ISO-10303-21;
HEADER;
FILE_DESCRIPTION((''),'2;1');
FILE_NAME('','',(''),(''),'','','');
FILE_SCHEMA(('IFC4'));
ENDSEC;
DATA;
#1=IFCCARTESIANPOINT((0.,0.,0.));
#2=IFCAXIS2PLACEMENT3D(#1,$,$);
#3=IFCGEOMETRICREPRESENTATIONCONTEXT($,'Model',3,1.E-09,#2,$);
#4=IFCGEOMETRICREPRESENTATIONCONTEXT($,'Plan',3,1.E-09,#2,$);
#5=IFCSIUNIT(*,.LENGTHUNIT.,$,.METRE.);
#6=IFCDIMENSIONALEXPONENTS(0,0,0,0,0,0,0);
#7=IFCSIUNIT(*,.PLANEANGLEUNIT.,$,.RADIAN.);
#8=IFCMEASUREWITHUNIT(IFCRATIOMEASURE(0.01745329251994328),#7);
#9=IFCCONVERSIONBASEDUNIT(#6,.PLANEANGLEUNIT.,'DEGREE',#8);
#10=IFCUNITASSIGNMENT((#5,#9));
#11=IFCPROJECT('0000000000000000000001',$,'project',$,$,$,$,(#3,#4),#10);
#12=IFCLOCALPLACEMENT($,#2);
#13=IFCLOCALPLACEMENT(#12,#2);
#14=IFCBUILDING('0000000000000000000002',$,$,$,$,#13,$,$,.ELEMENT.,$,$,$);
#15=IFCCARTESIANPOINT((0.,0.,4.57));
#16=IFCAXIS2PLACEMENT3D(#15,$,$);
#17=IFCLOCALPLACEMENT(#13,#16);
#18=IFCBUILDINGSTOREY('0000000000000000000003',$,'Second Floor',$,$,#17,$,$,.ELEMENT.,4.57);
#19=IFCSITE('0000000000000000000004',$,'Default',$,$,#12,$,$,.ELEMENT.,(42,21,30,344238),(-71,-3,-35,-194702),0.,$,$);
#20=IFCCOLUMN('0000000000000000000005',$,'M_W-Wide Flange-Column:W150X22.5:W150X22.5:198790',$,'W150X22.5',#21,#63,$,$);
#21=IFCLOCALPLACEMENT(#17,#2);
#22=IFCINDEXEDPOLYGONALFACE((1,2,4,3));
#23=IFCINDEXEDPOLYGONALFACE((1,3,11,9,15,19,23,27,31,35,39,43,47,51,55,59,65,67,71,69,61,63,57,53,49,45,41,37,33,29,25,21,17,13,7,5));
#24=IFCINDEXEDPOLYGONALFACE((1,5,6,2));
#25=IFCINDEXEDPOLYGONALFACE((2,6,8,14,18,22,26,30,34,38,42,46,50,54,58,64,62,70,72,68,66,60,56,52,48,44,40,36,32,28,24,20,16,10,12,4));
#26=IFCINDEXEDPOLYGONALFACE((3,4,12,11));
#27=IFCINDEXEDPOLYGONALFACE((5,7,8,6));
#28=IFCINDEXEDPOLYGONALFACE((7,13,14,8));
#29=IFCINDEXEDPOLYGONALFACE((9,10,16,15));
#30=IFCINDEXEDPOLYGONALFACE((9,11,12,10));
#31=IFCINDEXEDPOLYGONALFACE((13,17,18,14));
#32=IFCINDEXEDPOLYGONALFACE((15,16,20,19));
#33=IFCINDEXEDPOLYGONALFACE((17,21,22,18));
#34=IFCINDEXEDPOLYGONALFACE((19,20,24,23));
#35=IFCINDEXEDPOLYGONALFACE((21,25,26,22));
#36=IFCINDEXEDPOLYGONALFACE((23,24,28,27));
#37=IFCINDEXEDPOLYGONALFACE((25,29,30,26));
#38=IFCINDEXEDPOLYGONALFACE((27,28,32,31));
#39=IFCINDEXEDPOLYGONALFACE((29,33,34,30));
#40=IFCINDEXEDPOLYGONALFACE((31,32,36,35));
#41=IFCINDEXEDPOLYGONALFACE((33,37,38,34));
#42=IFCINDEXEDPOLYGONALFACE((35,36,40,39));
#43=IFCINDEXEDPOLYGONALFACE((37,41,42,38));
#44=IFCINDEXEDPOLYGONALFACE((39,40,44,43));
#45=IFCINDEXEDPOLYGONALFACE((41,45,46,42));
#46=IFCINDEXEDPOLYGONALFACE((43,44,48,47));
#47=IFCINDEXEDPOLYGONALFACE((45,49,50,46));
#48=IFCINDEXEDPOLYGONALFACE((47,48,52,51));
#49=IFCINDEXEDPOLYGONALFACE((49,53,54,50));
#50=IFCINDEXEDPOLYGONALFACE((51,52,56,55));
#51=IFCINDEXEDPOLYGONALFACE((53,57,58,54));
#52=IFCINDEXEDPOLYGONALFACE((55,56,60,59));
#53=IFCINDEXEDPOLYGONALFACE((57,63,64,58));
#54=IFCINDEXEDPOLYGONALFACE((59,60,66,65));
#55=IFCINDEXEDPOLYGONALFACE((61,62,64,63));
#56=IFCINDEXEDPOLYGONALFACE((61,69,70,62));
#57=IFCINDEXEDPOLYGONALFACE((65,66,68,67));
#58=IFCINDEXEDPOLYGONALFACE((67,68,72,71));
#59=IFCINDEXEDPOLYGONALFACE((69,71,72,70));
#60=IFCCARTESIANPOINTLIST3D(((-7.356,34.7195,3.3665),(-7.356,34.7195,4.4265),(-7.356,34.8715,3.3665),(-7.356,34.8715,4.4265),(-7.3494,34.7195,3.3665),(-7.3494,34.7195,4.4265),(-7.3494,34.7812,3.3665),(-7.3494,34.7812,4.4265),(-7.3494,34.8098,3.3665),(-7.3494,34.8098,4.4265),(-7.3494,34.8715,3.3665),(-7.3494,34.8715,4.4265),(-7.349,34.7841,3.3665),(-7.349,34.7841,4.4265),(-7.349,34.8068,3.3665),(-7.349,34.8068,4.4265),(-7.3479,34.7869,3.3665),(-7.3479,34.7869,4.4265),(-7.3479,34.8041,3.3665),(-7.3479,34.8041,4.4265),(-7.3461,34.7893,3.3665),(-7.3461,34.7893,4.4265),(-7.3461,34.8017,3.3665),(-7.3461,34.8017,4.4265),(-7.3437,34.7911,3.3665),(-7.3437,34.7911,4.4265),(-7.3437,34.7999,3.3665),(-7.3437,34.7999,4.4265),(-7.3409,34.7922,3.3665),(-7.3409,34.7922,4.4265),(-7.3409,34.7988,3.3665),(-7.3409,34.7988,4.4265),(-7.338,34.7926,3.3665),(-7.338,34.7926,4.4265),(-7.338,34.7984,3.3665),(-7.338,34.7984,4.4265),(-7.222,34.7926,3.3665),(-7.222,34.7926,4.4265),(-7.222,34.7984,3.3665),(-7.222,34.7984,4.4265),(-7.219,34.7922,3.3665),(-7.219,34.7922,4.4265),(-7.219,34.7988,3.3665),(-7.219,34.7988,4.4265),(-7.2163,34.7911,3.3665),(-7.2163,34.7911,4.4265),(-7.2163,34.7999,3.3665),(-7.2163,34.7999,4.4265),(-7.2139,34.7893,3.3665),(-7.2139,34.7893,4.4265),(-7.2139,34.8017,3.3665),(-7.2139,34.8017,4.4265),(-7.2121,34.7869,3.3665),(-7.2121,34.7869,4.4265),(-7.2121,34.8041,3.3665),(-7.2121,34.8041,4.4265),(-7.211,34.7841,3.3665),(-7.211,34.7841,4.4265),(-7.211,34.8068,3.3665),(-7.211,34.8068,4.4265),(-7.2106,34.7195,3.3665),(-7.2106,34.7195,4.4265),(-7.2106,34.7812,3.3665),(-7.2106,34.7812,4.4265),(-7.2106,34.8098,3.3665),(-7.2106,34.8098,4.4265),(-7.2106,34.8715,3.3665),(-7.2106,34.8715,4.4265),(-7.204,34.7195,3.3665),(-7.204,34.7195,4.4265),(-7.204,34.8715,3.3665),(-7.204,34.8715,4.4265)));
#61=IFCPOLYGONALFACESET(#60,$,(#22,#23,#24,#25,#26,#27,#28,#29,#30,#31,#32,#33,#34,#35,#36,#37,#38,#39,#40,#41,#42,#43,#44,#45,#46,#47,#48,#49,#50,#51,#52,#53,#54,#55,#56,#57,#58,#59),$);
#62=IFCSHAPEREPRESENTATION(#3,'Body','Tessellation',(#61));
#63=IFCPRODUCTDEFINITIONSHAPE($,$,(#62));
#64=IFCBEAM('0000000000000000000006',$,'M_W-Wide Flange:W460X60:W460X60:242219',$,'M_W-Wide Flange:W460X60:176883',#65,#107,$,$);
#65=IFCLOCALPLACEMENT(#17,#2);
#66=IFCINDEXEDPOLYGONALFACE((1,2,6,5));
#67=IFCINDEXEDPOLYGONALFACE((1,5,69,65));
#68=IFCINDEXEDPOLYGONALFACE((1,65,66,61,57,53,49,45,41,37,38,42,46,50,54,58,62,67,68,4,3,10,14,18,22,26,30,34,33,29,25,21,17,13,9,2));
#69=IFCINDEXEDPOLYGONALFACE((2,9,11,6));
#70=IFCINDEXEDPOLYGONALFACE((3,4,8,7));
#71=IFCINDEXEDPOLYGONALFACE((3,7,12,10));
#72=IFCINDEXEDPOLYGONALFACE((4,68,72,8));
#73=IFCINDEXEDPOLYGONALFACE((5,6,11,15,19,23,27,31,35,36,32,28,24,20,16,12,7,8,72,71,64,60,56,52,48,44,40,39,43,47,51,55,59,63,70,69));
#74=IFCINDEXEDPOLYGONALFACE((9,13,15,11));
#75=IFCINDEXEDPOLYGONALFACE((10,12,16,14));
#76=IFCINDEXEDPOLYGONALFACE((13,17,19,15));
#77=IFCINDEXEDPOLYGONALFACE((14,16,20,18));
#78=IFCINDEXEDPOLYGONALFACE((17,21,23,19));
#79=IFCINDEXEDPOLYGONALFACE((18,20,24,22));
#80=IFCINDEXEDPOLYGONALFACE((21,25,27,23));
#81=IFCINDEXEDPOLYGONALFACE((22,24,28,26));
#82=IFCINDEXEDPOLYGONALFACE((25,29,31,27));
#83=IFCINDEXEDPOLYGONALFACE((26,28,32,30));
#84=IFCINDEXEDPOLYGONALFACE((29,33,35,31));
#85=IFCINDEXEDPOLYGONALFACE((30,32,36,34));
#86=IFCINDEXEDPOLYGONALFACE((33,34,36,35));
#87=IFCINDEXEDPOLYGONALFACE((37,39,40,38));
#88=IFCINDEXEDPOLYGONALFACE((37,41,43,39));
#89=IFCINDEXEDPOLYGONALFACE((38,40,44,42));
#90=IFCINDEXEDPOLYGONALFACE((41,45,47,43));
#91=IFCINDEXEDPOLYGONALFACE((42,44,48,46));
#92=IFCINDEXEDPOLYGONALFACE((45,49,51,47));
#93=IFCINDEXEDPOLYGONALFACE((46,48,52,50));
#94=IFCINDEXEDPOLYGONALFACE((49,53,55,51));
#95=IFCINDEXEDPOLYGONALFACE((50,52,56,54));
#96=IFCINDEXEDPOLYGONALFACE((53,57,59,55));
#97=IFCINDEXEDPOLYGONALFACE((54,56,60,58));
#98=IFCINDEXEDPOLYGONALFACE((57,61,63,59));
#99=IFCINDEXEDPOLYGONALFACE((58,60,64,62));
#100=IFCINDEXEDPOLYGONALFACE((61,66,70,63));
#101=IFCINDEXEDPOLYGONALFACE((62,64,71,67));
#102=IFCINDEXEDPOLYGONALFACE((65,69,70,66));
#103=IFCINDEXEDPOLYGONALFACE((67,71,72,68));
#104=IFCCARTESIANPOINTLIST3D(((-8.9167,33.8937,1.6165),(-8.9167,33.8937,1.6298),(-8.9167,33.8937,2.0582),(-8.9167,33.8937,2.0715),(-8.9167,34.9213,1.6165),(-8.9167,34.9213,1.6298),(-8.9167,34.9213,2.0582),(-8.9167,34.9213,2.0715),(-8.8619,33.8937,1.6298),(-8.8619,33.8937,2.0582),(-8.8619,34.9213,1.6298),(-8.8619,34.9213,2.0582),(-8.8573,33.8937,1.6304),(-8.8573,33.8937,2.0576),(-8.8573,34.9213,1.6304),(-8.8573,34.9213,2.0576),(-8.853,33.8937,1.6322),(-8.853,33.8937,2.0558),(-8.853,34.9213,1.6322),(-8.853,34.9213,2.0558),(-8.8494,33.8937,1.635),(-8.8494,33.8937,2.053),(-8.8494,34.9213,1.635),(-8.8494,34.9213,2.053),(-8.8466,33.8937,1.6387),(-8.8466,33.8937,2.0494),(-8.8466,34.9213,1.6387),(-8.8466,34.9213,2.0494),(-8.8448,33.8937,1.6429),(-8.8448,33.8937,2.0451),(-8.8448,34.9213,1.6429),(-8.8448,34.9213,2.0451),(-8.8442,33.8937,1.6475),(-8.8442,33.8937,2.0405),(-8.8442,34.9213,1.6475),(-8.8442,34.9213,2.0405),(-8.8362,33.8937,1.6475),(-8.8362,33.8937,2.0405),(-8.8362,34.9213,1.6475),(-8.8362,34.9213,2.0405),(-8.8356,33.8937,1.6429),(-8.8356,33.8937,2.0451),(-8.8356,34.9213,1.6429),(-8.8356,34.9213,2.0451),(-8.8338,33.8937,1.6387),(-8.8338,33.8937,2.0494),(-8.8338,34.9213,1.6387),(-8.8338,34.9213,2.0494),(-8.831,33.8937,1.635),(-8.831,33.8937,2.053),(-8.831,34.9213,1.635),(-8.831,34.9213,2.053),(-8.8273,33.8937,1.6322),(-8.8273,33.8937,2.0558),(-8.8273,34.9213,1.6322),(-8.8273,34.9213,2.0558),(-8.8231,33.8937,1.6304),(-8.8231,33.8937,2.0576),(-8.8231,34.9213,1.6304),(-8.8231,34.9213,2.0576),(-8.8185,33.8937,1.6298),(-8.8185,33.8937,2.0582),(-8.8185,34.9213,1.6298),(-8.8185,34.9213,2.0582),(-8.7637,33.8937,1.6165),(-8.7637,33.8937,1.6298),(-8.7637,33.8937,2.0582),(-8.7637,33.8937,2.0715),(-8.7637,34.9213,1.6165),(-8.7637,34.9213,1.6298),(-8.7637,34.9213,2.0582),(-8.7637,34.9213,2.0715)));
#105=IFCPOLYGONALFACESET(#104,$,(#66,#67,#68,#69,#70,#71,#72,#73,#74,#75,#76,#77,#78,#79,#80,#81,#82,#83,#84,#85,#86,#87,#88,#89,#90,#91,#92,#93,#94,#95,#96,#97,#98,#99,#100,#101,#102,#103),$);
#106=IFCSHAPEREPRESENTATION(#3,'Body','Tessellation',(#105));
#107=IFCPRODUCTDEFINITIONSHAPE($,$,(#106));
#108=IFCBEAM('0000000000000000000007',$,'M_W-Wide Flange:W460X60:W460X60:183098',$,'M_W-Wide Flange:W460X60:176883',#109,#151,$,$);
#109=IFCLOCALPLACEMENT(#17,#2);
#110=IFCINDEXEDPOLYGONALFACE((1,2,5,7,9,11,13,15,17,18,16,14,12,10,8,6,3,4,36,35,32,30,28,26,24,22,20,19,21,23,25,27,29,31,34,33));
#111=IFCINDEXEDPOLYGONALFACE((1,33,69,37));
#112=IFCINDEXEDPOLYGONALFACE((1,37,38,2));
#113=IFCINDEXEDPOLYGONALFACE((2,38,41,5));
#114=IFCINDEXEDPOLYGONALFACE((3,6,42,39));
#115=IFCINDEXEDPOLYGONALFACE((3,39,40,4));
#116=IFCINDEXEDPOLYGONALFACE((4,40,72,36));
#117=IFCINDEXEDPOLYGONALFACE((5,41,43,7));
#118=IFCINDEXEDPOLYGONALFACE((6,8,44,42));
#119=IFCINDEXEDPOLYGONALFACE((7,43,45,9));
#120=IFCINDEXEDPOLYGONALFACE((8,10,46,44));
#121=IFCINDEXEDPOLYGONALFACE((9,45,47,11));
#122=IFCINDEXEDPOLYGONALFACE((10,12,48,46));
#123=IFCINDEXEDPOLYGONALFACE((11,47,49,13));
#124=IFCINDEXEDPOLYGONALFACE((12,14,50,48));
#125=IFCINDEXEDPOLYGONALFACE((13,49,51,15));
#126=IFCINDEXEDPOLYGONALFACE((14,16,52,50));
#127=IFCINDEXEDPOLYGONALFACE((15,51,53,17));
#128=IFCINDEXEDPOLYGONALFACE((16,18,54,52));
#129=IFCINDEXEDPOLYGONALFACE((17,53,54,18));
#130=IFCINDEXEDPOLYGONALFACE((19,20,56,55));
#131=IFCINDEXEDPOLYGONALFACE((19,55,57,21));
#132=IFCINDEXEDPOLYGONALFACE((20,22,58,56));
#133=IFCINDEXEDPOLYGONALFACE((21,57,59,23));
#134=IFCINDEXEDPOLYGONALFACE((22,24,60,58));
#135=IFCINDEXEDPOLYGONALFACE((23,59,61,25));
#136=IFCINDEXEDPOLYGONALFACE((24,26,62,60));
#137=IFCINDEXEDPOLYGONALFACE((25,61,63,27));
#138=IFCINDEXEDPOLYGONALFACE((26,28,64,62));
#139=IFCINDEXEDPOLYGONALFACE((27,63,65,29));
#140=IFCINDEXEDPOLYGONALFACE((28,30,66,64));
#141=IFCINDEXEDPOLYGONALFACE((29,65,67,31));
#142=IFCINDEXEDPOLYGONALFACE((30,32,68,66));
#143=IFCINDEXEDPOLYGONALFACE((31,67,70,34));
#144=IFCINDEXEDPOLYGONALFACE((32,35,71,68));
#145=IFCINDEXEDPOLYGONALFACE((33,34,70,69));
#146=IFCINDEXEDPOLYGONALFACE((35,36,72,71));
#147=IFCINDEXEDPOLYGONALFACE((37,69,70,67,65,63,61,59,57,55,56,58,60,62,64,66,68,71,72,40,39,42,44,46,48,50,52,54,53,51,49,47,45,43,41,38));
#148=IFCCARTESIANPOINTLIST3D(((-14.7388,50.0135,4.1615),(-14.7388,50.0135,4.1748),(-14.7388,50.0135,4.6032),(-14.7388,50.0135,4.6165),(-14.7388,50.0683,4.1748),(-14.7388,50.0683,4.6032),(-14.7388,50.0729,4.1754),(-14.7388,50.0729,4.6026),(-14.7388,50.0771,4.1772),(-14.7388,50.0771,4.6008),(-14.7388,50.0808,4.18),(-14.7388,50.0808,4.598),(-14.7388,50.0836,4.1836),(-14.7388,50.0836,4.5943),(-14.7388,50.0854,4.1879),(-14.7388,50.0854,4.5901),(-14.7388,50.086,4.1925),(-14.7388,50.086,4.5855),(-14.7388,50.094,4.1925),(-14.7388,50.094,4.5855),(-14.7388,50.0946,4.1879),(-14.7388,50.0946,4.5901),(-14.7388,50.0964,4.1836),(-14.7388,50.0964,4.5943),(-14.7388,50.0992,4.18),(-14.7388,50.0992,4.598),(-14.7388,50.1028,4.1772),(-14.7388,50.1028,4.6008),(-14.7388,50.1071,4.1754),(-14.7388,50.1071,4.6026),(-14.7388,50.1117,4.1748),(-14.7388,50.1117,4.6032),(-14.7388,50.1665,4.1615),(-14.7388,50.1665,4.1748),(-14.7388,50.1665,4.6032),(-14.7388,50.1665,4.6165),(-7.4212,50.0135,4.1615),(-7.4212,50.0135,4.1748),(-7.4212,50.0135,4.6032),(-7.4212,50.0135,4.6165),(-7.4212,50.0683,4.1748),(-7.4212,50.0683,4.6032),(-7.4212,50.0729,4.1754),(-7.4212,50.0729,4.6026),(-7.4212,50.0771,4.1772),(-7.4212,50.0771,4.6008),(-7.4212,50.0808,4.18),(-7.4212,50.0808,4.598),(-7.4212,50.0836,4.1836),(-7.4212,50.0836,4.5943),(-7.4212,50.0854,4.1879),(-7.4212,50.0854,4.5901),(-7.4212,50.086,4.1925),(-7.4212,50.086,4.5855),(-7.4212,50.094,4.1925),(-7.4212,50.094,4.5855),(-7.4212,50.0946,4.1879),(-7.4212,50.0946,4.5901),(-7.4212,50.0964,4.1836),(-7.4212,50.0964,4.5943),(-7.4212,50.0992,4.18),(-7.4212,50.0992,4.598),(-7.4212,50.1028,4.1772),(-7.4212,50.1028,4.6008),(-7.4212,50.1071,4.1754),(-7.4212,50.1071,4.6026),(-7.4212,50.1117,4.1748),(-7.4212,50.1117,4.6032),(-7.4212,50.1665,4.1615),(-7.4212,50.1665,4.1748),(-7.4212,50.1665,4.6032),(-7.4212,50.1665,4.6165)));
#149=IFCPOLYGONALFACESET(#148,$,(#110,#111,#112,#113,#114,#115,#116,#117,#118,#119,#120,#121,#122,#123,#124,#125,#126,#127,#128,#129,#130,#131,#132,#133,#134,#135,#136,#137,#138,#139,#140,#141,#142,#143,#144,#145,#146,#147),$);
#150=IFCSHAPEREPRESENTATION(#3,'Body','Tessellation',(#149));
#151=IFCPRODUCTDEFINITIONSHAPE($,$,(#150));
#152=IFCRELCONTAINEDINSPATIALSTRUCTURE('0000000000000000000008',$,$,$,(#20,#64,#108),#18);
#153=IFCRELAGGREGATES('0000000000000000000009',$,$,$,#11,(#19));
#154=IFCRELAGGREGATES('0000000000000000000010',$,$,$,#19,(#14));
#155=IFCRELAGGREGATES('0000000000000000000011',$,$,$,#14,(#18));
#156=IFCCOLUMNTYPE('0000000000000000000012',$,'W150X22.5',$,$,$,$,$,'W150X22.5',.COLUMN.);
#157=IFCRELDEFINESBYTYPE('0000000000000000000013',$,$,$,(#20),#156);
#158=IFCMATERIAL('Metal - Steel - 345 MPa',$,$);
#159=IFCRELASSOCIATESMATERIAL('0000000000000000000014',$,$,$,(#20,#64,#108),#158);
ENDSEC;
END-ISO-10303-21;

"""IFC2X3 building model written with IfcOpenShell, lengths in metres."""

from ifc_helpers import new_model, entity, si_unit, converted_unit, frame, frame_2d, origin, place, context, project, spatial, polyline, circle_curve, parameter, trimmed, segment, composite_curve, outline, extrude, source, transform, mapped, material, type_object, type_shapes, element, save


model = new_model("IFC2X3")

# Units and contexts
model_context = context("Model", 3, precision=1e-09, world=origin())
plan_context = context("Plan", 3, precision=1e-09, world=origin())
ifc_project = project(units=[si_unit("LENGTHUNIT", "METRE"), converted_unit("PLANEANGLEUNIT", "DEGREE", entity("IfcRatioMeasure", 0.01745329251994328), si_unit("PLANEANGLEUNIT", "RADIAN"), dimensions=[0, 0, 0, 0, 0, 0, 0])], contexts=[model_context, plan_context])

# Site, building, storey
site_placement = place(None, origin())
site = spatial("IfcSite", under=ifc_project, at=site_placement, Name="Default", CompositionType="ELEMENT", RefLatitude=(42, 21, 30, 344238), RefLongitude=(-71, -3, -35, -194702), RefElevation=0.0)
building_placement = place(site_placement, origin())
building = spatial("IfcBuilding", under=site, at=building_placement, CompositionType="ELEMENT")
storey_placement = place(building_placement, frame((0.0, 0.0, 4.57)))
storey = spatial("IfcBuildingStorey", under=building, at=storey_placement, Name="Second Floor", CompositionType="ELEMENT", Elevation=4.57)

# Column
ifc_material = material(Name="Metal - Steel - 345 MPa")
column_type_1 = type_object("IfcColumnType", Name="W150X22.5", ElementType="W150X22.5", PredefinedType="COLUMN")
shared_shape_1 = source(origin(), model_context, "Body", "SweptSolid", [
    extrude(outline(composite_curve([segment(polyline([(-0.076, -0.076), (0.076, -0.076)]), True, "CONTINUOUS"), segment(polyline([(0.076, -0.076), (0.076, -0.0694)]), True, "CONTINUOUS"), segment(polyline([(0.076, -0.0694), (0.0143, -0.0694)]), True, "CONTINUOUS"), segment(trimmed(circle_curve(frame_2d((0.0143, -0.058), x_axis=(-1.0, 0.0)), 0.0114), [parameter(0.0)], [parameter(90.0)], True, "PARAMETER"), False, "CONTINUOUS"), segment(polyline([(0.0029, -0.058), (0.0029, 0.058)]), True, "CONTINUOUS"), segment(trimmed(circle_curve(frame_2d((0.0143, 0.058), x_axis=(-1.0, 0.0)), 0.0114), [parameter(270.0)], [parameter(0.0)], True, "PARAMETER"), False, "CONTINUOUS"), segment(polyline([(0.0143, 0.0694), (0.076, 0.0694)]), True, "CONTINUOUS"), segment(polyline([(0.076, 0.0694), (0.076, 0.076)]), True, "CONTINUOUS"), segment(polyline([(0.076, 0.076), (-0.076, 0.076)]), True, "CONTINUOUS"), segment(polyline([(-0.076, 0.076), (-0.076, 0.0694)]), True, "CONTINUOUS"), segment(polyline([(-0.076, 0.0694), (-0.0143, 0.0694)]), True, "CONTINUOUS"), segment(trimmed(circle_curve(frame_2d((-0.0143, 0.058), x_axis=(-1.0, 0.0)), 0.0114), [parameter(180.0)], [parameter(270.0)], True, "PARAMETER"), False, "CONTINUOUS"), segment(polyline([(-0.0029, 0.058), (-0.0029, -0.058)]), True, "CONTINUOUS"), segment(trimmed(circle_curve(frame_2d((-0.0143, -0.058), x_axis=(-1.0, 0.0)), 0.0114), [parameter(90.0)], [parameter(180.0)], True, "PARAMETER"), False, "CONTINUOUS"), segment(polyline([(-0.0143, -0.0694), (-0.076, -0.0694)]), True, "CONTINUOUS"), segment(polyline([(-0.076, -0.0694), (-0.076, -0.076)]), True, "CONTINUOUS")], self_intersect=False)), frame((0.0, 0.0, 7.9365), z_axis=(0.0, 0.0, 1.0), x_axis=(-1.0, 0.0, 0.0)), (0.0, 0.0, 1.0), 1.06),
])
type_shapes(column_type_1, [shared_shape_1])
for number, where, z_axis, x_axis, name in (
    (1, (-7.28, 34.7955, -4.57), (0.0, 0.0, 1.0), (0.0, 1.0, 0.0), "M_W-Wide Flange-Column:W150X22.5:W150X22.5:198790"),
):
    element("IfcColumn", number, at=place(storey_placement, frame(where, z_axis=z_axis, x_axis=x_axis)), inside=storey, type_object=column_type_1, material=ifc_material, Name=name, ObjectType="W150X22.5", context=model_context, shape_type="MappedRepresentation", body=[
        mapped(shared_shape_1, transform((0.0, 0.0, 0.0), scale=1.0)),
    ])

# Beams
beam_1_placement = place(storey_placement, frame((-8.8402, 35.9378, 2.0715)))
element("IfcBeam", 2, at=beam_1_placement, inside=storey, material=ifc_material, Name="M_W-Wide Flange:W460X60:W460X60:242219", ObjectType="M_W-Wide Flange:W460X60:176883", context=model_context, shape_type="SweptSolid", body=[
    extrude(outline(composite_curve([segment(polyline([(0.2142, -0.0765), (0.2275, -0.0765)]), True, "CONTINUOUS"), segment(polyline([(0.2275, -0.0765), (0.2275, 0.0765)]), True, "CONTINUOUS"), segment(polyline([(0.2275, 0.0765), (0.2142, 0.0765)]), True, "CONTINUOUS"), segment(polyline([(0.2142, 0.0765), (0.2142, 0.0217)]), True, "CONTINUOUS"), segment(trimmed(circle_curve(frame_2d((0.1965, 0.0217), x_axis=(0.0, 1.0)), 0.0177), [parameter(180.0)], [parameter(270.0)], True, "PARAMETER"), False, "CONTINUOUS"), segment(polyline([(0.1965, 0.004), (-0.1965, 0.004)]), True, "CONTINUOUS"), segment(trimmed(circle_curve(frame_2d((-0.1965, 0.0217), x_axis=(0.0, 1.0)), 0.0177), [parameter(90.0)], [parameter(180.0)], True, "PARAMETER"), False, "CONTINUOUS"), segment(polyline([(-0.2142, 0.0217), (-0.2142, 0.0765)]), True, "CONTINUOUS"), segment(polyline([(-0.2142, 0.0765), (-0.2275, 0.0765)]), True, "CONTINUOUS"), segment(polyline([(-0.2275, 0.0765), (-0.2275, -0.0765)]), True, "CONTINUOUS"), segment(polyline([(-0.2275, -0.0765), (-0.2142, -0.0765)]), True, "CONTINUOUS"), segment(polyline([(-0.2142, -0.0765), (-0.2142, -0.0217)]), True, "CONTINUOUS"), segment(trimmed(circle_curve(frame_2d((-0.1965, -0.0217), x_axis=(0.0, 1.0)), 0.0177), [parameter(360.0)], [parameter(90.0)], True, "PARAMETER"), False, "CONTINUOUS"), segment(polyline([(-0.1965, -0.004), (0.1965, -0.004)]), True, "CONTINUOUS"), segment(trimmed(circle_curve(frame_2d((0.1965, -0.0217), x_axis=(0.0, 1.0)), 0.0177), [parameter(270.0)], [parameter(0.0)], True, "PARAMETER"), False, "CONTINUOUS"), segment(polyline([(0.2142, -0.0217), (0.2142, -0.0765)]), True, "CONTINUOUS")], self_intersect=False)), frame((0.0, -2.0441, -0.2275), z_axis=(0.0, 1.0, 0.0), x_axis=(0.0, 0.0, -1.0)), (0.0, 0.0, 1.0), 1.0276),
])
beam_2_placement = place(storey_placement, frame((-7.2825, 50.09, 4.6165), z_axis=(0.0, 0.0, 1.0), x_axis=(0.0, 1.0, 0.0)))
element("IfcBeam", 3, at=beam_2_placement, inside=storey, material=ifc_material, Name="M_W-Wide Flange:W460X60:W460X60:183098", ObjectType="M_W-Wide Flange:W460X60:176883", context=model_context, shape_type="SweptSolid", body=[
    extrude(outline(composite_curve([segment(polyline([(0.2142, -0.0765), (0.2275, -0.0765)]), True, "CONTINUOUS"), segment(polyline([(0.2275, -0.0765), (0.2275, 0.0765)]), True, "CONTINUOUS"), segment(polyline([(0.2275, 0.0765), (0.2142, 0.0765)]), True, "CONTINUOUS"), segment(polyline([(0.2142, 0.0765), (0.2142, 0.0217)]), True, "CONTINUOUS"), segment(trimmed(circle_curve(frame_2d((0.1965, 0.0217), x_axis=(1.0, 0.0)), 0.0177), [parameter(270.0)], [parameter(360.0)], True, "PARAMETER"), False, "CONTINUOUS"), segment(polyline([(0.1965, 0.004), (-0.1965, 0.004)]), True, "CONTINUOUS"), segment(trimmed(circle_curve(frame_2d((-0.1965, 0.0217), x_axis=(0.0, -1.0)), 0.0177), [parameter(270.0)], [parameter(360.0)], True, "PARAMETER"), False, "CONTINUOUS"), segment(polyline([(-0.2142, 0.0217), (-0.2142, 0.0765)]), True, "CONTINUOUS"), segment(polyline([(-0.2142, 0.0765), (-0.2275, 0.0765)]), True, "CONTINUOUS"), segment(polyline([(-0.2275, 0.0765), (-0.2275, -0.0765)]), True, "CONTINUOUS"), segment(polyline([(-0.2275, -0.0765), (-0.2142, -0.0765)]), True, "CONTINUOUS"), segment(polyline([(-0.2142, -0.0765), (-0.2142, -0.0217)]), True, "CONTINUOUS"), segment(trimmed(circle_curve(frame_2d((-0.1965, -0.0217), x_axis=(-1.0, 0.0)), 0.0177), [parameter(270.0)], [parameter(360.0)], True, "PARAMETER"), False, "CONTINUOUS"), segment(polyline([(-0.1965, -0.004), (0.1965, -0.004)]), True, "CONTINUOUS"), segment(trimmed(circle_curve(frame_2d((0.1965, -0.0217), x_axis=(0.0, 1.0)), 0.0177), [parameter(270.0)], [parameter(0.0)], True, "PARAMETER"), False, "CONTINUOUS"), segment(polyline([(0.2142, -0.0217), (0.2142, -0.0765)]), True, "CONTINUOUS")], self_intersect=False)), frame((0.0, 7.4563, -0.2275), z_axis=(0.0, -1.0, 0.0), x_axis=(0.0, 0.0, -1.0)), (0.0, 0.0, 1.0), 7.3176),
])

save(model, "model.ifc")
